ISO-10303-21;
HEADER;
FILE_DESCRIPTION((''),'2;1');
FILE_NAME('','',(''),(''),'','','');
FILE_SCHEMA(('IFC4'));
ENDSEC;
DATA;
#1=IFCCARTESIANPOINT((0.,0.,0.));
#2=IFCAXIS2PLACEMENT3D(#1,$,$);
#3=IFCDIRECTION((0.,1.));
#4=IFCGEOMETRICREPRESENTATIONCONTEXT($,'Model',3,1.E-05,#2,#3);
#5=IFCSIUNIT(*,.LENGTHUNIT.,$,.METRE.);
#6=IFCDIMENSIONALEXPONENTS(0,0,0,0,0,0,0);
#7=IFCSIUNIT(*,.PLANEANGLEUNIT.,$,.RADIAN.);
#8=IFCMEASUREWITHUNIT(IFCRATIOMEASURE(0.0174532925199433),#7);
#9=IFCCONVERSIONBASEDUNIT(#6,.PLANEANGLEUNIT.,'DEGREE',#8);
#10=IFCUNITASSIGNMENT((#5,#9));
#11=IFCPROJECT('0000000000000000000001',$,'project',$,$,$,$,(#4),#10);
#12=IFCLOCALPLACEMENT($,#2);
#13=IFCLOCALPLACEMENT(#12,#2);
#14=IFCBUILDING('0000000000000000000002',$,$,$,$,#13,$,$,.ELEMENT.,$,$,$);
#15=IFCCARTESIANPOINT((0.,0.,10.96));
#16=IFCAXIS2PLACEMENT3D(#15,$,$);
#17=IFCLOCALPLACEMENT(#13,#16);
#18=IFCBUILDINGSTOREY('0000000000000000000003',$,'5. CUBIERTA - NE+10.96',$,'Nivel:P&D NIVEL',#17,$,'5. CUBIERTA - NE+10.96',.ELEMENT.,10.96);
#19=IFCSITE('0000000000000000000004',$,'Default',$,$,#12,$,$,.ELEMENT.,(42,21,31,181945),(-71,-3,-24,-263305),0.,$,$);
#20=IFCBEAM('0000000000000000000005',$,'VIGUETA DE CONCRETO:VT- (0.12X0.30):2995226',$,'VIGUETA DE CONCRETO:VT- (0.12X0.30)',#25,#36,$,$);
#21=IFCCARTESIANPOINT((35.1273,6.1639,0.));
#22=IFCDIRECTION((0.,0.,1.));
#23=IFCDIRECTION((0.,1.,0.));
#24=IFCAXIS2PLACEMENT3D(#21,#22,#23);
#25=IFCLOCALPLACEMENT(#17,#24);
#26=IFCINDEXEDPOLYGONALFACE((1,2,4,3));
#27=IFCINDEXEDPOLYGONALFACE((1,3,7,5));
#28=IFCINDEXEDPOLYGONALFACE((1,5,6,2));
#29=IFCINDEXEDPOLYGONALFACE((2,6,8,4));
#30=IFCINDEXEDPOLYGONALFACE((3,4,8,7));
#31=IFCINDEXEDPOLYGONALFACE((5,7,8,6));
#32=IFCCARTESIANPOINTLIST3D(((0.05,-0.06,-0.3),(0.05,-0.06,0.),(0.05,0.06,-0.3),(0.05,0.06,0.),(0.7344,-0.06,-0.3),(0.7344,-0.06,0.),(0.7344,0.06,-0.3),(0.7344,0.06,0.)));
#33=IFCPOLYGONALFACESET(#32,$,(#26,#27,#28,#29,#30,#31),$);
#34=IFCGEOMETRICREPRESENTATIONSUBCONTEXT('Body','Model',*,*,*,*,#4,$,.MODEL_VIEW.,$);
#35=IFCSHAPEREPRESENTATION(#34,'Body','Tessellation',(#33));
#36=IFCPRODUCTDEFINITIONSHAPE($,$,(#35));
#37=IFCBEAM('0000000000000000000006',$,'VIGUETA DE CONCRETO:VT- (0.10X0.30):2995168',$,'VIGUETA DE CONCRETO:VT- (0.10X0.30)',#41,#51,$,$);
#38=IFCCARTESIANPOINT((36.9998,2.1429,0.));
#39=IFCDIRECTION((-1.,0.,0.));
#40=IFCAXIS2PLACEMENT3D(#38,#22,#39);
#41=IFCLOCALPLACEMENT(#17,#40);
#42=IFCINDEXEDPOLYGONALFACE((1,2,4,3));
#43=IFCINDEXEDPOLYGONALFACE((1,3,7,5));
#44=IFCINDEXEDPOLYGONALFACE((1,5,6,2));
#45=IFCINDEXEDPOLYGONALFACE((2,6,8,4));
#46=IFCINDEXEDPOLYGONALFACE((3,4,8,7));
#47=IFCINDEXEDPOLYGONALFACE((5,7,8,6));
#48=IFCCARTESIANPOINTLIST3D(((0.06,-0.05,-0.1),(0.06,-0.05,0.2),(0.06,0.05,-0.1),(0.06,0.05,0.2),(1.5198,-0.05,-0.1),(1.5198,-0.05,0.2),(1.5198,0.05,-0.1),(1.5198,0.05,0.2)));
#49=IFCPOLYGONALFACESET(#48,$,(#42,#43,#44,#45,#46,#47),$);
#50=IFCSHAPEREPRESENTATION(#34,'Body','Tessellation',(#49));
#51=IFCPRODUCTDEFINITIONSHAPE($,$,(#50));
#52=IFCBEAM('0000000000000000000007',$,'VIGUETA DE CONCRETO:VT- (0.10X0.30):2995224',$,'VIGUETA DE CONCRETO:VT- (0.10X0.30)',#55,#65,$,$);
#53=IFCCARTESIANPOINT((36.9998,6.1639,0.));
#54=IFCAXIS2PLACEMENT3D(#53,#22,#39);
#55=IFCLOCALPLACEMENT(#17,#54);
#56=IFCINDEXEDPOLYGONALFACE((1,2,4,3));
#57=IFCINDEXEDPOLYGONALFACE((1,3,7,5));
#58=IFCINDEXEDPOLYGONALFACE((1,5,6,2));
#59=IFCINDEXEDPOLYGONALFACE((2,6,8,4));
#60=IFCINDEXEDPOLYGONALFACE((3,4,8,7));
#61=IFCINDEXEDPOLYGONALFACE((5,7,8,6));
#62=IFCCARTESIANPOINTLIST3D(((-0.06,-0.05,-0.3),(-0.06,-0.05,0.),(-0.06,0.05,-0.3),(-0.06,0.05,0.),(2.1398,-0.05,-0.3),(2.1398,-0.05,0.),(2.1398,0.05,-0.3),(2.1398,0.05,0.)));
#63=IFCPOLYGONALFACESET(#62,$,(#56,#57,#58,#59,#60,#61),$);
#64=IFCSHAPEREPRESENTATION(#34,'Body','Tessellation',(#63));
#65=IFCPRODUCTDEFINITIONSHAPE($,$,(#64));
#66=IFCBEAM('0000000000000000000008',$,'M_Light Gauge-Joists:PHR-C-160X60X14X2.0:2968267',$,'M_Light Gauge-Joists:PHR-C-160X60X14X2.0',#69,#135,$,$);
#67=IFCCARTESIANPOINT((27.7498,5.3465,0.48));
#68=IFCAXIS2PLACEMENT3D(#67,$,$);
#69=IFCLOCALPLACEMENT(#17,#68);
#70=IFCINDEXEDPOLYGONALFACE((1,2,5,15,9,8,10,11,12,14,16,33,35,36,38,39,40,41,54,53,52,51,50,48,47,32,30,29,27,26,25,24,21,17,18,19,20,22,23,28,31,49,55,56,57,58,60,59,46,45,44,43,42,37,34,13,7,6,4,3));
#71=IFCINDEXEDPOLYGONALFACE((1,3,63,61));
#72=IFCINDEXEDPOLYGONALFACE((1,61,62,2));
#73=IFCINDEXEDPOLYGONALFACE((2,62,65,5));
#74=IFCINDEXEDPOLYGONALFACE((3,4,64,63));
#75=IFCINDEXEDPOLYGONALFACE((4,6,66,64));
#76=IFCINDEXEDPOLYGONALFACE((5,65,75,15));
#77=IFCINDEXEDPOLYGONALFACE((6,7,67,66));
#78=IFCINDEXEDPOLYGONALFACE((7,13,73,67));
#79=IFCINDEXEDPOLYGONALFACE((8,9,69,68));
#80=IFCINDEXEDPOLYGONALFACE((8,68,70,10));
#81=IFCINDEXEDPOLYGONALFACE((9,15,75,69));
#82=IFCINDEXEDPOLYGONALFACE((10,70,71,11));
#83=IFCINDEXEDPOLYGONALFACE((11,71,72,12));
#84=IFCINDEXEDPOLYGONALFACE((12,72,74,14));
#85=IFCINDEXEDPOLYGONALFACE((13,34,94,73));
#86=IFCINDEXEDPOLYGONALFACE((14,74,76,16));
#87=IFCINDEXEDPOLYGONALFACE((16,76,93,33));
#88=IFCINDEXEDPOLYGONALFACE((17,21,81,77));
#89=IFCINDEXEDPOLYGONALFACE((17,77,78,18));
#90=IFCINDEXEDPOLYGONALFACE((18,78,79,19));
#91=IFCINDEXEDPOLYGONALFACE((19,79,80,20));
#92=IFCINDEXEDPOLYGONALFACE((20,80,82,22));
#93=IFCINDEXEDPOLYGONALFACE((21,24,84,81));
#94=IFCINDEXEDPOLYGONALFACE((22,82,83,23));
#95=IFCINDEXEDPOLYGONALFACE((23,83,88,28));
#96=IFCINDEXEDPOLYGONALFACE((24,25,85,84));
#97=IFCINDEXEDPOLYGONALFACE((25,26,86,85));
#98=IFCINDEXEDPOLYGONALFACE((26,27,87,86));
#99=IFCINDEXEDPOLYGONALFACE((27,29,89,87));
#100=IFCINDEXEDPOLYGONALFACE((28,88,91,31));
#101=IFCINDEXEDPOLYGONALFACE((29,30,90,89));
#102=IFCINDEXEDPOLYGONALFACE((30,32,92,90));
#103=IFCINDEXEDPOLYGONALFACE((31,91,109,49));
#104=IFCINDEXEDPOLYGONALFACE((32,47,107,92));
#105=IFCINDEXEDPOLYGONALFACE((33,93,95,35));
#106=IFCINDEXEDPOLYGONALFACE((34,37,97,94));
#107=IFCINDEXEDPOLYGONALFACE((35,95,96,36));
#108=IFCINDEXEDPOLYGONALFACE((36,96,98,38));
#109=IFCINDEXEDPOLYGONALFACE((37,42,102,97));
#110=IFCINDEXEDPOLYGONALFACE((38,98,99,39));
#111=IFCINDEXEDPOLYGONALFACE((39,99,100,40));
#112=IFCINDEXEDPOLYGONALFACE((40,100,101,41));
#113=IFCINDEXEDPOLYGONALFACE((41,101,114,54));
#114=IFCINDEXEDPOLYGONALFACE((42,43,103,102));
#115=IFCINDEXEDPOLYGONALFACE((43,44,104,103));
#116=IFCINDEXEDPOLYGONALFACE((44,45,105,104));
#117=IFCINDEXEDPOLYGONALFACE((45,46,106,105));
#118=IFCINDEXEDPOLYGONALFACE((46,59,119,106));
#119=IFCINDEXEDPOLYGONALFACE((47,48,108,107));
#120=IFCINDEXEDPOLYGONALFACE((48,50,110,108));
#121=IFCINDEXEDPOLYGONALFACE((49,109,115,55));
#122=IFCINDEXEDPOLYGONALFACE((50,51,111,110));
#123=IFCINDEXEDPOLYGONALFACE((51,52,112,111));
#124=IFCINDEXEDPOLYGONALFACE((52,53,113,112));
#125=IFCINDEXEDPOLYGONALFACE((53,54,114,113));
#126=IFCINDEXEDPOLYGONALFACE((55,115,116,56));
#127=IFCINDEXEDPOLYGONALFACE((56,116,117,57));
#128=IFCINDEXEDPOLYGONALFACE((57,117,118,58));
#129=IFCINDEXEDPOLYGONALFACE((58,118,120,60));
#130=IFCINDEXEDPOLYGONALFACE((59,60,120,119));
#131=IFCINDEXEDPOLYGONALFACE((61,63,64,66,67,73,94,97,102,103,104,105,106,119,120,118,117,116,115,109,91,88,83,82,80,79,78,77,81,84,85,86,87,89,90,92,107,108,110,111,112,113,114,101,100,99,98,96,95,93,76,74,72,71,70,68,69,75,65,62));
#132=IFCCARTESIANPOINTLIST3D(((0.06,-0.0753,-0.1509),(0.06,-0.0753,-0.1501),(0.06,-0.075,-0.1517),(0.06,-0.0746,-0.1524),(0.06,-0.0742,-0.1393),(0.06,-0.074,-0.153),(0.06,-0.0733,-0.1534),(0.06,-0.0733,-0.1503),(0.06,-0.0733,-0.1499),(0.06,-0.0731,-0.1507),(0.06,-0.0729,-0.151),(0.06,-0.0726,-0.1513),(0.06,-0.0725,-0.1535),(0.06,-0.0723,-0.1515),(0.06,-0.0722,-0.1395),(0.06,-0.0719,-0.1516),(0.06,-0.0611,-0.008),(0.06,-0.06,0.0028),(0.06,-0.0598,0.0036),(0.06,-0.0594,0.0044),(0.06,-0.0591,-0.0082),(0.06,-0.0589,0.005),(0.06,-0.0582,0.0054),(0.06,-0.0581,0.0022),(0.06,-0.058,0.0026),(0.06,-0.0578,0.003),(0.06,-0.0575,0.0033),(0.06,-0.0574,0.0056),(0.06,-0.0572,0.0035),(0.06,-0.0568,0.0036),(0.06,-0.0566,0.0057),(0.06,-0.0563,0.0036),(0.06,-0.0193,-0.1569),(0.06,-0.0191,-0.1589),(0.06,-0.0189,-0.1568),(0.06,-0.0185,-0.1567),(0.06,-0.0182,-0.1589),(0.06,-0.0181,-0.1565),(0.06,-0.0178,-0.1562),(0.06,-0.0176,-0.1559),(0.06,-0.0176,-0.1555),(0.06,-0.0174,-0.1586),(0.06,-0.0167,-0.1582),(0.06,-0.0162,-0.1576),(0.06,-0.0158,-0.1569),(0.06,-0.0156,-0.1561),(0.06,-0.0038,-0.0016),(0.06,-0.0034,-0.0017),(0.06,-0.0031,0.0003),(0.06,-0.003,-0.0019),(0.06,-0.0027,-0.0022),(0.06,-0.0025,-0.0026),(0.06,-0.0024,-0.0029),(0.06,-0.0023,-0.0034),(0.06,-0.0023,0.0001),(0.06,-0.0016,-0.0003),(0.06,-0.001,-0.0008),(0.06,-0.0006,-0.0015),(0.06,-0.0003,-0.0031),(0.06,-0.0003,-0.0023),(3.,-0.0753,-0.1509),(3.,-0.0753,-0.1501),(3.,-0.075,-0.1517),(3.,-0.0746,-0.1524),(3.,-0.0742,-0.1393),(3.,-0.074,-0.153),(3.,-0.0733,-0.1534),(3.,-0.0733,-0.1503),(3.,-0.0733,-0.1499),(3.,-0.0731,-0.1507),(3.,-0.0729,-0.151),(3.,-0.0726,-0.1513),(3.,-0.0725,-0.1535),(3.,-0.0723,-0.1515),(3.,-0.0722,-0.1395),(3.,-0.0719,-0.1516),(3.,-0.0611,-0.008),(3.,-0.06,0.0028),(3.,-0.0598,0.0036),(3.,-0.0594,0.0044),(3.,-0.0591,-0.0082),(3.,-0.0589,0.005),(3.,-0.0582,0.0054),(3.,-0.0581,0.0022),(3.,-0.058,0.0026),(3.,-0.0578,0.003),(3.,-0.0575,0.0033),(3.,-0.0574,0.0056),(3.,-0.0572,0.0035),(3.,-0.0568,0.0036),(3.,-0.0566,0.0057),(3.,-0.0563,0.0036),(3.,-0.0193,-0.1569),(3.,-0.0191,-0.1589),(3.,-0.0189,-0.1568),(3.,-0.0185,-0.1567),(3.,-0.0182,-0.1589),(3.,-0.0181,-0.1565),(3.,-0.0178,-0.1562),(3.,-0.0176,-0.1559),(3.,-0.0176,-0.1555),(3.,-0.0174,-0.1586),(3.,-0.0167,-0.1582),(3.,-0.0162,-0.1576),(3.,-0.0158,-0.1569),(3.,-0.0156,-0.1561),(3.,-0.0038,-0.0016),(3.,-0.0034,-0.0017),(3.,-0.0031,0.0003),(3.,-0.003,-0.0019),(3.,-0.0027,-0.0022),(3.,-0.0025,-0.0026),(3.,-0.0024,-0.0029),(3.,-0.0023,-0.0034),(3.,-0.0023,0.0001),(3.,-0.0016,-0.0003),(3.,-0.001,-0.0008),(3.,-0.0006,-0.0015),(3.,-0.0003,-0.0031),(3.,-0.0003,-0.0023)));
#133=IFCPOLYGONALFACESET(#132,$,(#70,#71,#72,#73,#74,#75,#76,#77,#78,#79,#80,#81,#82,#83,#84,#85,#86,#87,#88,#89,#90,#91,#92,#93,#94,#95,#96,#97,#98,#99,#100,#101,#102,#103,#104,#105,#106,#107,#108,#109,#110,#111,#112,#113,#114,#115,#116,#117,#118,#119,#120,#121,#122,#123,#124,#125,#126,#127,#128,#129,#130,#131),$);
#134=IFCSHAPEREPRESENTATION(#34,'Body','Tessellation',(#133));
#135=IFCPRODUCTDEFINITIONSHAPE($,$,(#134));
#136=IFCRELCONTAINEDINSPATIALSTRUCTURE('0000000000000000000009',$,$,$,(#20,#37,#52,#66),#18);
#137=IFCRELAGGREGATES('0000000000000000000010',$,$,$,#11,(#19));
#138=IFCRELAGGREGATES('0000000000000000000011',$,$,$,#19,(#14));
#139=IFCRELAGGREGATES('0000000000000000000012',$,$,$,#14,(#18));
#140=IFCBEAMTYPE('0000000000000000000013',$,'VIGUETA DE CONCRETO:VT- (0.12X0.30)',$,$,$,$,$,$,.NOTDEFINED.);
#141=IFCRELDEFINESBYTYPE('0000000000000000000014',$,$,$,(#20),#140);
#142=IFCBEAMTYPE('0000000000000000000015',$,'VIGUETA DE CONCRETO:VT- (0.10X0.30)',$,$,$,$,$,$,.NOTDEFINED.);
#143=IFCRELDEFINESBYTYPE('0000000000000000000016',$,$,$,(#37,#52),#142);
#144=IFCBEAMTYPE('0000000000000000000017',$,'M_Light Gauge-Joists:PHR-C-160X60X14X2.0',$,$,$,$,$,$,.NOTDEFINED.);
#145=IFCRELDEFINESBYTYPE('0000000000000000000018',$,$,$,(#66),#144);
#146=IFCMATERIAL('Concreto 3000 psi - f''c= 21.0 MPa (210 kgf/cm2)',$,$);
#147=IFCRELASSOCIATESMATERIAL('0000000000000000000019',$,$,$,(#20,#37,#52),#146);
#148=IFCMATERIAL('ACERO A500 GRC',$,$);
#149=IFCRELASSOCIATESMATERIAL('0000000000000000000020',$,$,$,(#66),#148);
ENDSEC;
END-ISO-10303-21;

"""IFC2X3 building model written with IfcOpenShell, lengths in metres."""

from ifc_helpers import new_model, entity, si_unit, converted_unit, direction, frame, frame_2d, origin, place, context, subcontext, project, spatial, polyline, circle_curve, parameter, trimmed, segment, composite_curve, rectangle, outline, extrude, material, type_object, element, save


model = new_model("IFC2X3")

# Units and contexts
model_context = context("Model", 3, precision=1e-05, world=origin(), true_north=direction((0.0, 1.0)))
body_context = subcontext(model_context, "Body", "Model", "MODEL_VIEW")
ifc_project = project(units=[si_unit("LENGTHUNIT", "METRE"), converted_unit("PLANEANGLEUNIT", "DEGREE", entity("IfcRatioMeasure", 0.0174532925199433), si_unit("PLANEANGLEUNIT", "RADIAN"), dimensions=[0, 0, 0, 0, 0, 0, 0])], contexts=[model_context])

# Site, building, storey
site_placement = place(None, origin())
site = spatial("IfcSite", under=ifc_project, at=site_placement, Name="Default", CompositionType="ELEMENT", RefLatitude=(42, 21, 31, 181945), RefLongitude=(-71, -3, -24, -263305), RefElevation=0.0)
building_placement = place(site_placement, origin())
building = spatial("IfcBuilding", under=site, at=building_placement, CompositionType="ELEMENT")
storey_placement = place(building_placement, frame((0.0, 0.0, 10.96)))
storey = spatial("IfcBuildingStorey", under=building, at=storey_placement, Name="5. CUBIERTA - NE+10.96", ObjectType="Nivel:P&D NIVEL", LongName="5. CUBIERTA - NE+10.96", CompositionType="ELEMENT", Elevation=10.96)

# Beams
ifc_material_1 = material(Name="Concreto 3000 psi - f'c= 21.0 MPa (210 kgf/cm2)")
beam_type_1 = type_object("IfcBeamType", Name="VIGUETA DE CONCRETO:VT- (0.12X0.30)", PredefinedType="NOTDEFINED")
beam_1_placement = place(storey_placement, frame((35.1273, 6.1639, 0.0), z_axis=(0.0, 0.0, 1.0), x_axis=(0.0, 1.0, 0.0)))
element("IfcBeam", 1, at=beam_1_placement, inside=storey, type_object=beam_type_1, material=ifc_material_1, Name="VIGUETA DE CONCRETO:VT- (0.12X0.30):2995226", ObjectType="VIGUETA DE CONCRETO:VT- (0.12X0.30)", context=body_context, shape_type="SweptSolid", body=[
    extrude(rectangle(XDim=0.3, YDim=0.12, at=frame_2d((0.0, 0.0), x_axis=(1.0, 0.0))), frame((0.05, 0.0, -0.15), z_axis=(1.0, 0.0, 0.0), x_axis=(0.0, 0.0, -1.0)), (0.0, 0.0, 1.0), 0.6844),
])
beam_type_2 = type_object("IfcBeamType", Name="VIGUETA DE CONCRETO:VT- (0.10X0.30)", PredefinedType="NOTDEFINED")
beam_2_placement = place(storey_placement, frame((36.9998, 2.1429, 0.0), z_axis=(0.0, 0.0, 1.0), x_axis=(-1.0, 0.0, 0.0)))
element("IfcBeam", 2, at=beam_2_placement, inside=storey, type_object=beam_type_2, material=ifc_material_1, Name="VIGUETA DE CONCRETO:VT- (0.10X0.30):2995168", ObjectType="VIGUETA DE CONCRETO:VT- (0.10X0.30)", context=body_context, shape_type="SweptSolid", body=[
    extrude(rectangle(XDim=0.3, YDim=0.1, at=frame_2d((0.0, 0.0), x_axis=(1.0, 0.0))), frame((0.06, 0.0, 0.05), z_axis=(1.0, 0.0, 0.0), x_axis=(0.0, 0.0, -1.0)), (0.0, 0.0, 1.0), 1.4598),
])
beam_3_placement = place(storey_placement, frame((36.9998, 6.1639, 0.0), z_axis=(0.0, 0.0, 1.0), x_axis=(-1.0, 0.0, 0.0)))
element("IfcBeam", 3, at=beam_3_placement, inside=storey, type_object=beam_type_2, material=ifc_material_1, Name="VIGUETA DE CONCRETO:VT- (0.10X0.30):2995224", ObjectType="VIGUETA DE CONCRETO:VT- (0.10X0.30)", context=body_context, shape_type="SweptSolid", body=[
    extrude(rectangle(XDim=0.3, YDim=0.1, at=frame_2d((0.0, 0.0), x_axis=(1.0, 0.0))), frame((-0.06, 0.0, -0.15), z_axis=(1.0, 0.0, 0.0), x_axis=(0.0, 0.0, -1.0)), (0.0, 0.0, 1.0), 2.1998),
])
ifc_material_2 = material(Name="ACERO A500 GRC")
beam_type_3 = type_object("IfcBeamType", Name="M_Light Gauge-Joists:PHR-C-160X60X14X2.0", PredefinedType="NOTDEFINED")
beam_4_placement = place(storey_placement, frame((27.7498, 5.3465, 0.48)))
element("IfcBeam", 4, at=beam_4_placement, inside=storey, type_object=beam_type_3, material=ifc_material_2, Name="M_Light Gauge-Joists:PHR-C-160X60X14X2.0:2968267", ObjectType="M_Light Gauge-Joists:PHR-C-160X60X14X2.0", context=body_context, shape_type="SweptSolid", body=[
    extrude(outline(composite_curve([segment(polyline([(-0.0768, -0.0358), (0.0768, -0.0358)]), True, "CONTINUOUS"), segment(trimmed(circle_curve(frame_2d((0.0768, -0.0326), x_axis=(0.0, -1.0)), 0.0032), [parameter(0.0)], [parameter(90.0)], True, "PARAMETER"), True, "CONTINUOUS"), segment(polyline([(0.08, -0.0326), (0.08, 0.021)]), True, "CONTINUOUS"), segment(trimmed(circle_curve(frame_2d((0.0768, 0.021), x_axis=(1.0, 0.0)), 0.0032), [parameter(0.0)], [parameter(90.0)], True, "PARAMETER"), True, "CONTINUOUS"), segment(polyline([(0.0768, 0.0242), (0.066, 0.0242)]), True, "CONTINUOUS"), segment(polyline([(0.066, 0.0242), (0.066, 0.0222)]), True, "CONTINUOUS"), segment(polyline([(0.066, 0.0222), (0.0764, 0.0222)]), True, "CONTINUOUS"), segment(trimmed(circle_curve(frame_2d((0.0764, 0.0206), x_axis=(0.0, 1.0)), 0.0016), [parameter(270.0)], [parameter(0.0)], True, "PARAMETER"), False, "CONTINUOUS"), segment(polyline([(0.078, 0.0206), (0.078, -0.0322)]), True, "CONTINUOUS"), segment(trimmed(circle_curve(frame_2d((0.0764, -0.0322), x_axis=(1.0, 0.0)), 0.0016), [parameter(270.0)], [parameter(0.0)], True, "PARAMETER"), False, "CONTINUOUS"), segment(polyline([(0.0764, -0.0338), (-0.0764, -0.0338)]), True, "CONTINUOUS"), segment(trimmed(circle_curve(frame_2d((-0.0764, -0.0322), x_axis=(0.0, -1.0)), 0.0016), [parameter(270.0)], [parameter(0.0)], True, "PARAMETER"), False, "CONTINUOUS"), segment(polyline([(-0.078, -0.0322), (-0.078, 0.0206)]), True, "CONTINUOUS"), segment(trimmed(circle_curve(frame_2d((-0.0764, 0.0206), x_axis=(-1.0, 0.0)), 0.0016), [parameter(270.0)], [parameter(0.0)], True, "PARAMETER"), False, "CONTINUOUS"), segment(polyline([(-0.0764, 0.0222), (-0.066, 0.0222)]), True, "CONTINUOUS"), segment(polyline([(-0.066, 0.0222), (-0.066, 0.0242)]), True, "CONTINUOUS"), segment(polyline([(-0.066, 0.0242), (-0.0768, 0.0242)]), True, "CONTINUOUS"), segment(trimmed(circle_curve(frame_2d((-0.0768, 0.021), x_axis=(0.0, 1.0)), 0.0032), [parameter(0.0)], [parameter(90.0)], True, "PARAMETER"), True, "CONTINUOUS"), segment(polyline([(-0.08, 0.021), (-0.08, -0.0326)]), True, "CONTINUOUS"), segment(trimmed(circle_curve(frame_2d((-0.0768, -0.0326), x_axis=(-1.0, 0.0)), 0.0032), [parameter(0.0)], [parameter(90.0)], True, "PARAMETER"), True, "CONTINUOUS")], self_intersect=False)), frame((0.06, -0.0436, -0.076), z_axis=(1.0, 0.0, 0.0), x_axis=(0.0, 0.099504, 0.995037)), (0.0, 0.0, 1.0), 2.94),
])

save(model, "model.ifc")
